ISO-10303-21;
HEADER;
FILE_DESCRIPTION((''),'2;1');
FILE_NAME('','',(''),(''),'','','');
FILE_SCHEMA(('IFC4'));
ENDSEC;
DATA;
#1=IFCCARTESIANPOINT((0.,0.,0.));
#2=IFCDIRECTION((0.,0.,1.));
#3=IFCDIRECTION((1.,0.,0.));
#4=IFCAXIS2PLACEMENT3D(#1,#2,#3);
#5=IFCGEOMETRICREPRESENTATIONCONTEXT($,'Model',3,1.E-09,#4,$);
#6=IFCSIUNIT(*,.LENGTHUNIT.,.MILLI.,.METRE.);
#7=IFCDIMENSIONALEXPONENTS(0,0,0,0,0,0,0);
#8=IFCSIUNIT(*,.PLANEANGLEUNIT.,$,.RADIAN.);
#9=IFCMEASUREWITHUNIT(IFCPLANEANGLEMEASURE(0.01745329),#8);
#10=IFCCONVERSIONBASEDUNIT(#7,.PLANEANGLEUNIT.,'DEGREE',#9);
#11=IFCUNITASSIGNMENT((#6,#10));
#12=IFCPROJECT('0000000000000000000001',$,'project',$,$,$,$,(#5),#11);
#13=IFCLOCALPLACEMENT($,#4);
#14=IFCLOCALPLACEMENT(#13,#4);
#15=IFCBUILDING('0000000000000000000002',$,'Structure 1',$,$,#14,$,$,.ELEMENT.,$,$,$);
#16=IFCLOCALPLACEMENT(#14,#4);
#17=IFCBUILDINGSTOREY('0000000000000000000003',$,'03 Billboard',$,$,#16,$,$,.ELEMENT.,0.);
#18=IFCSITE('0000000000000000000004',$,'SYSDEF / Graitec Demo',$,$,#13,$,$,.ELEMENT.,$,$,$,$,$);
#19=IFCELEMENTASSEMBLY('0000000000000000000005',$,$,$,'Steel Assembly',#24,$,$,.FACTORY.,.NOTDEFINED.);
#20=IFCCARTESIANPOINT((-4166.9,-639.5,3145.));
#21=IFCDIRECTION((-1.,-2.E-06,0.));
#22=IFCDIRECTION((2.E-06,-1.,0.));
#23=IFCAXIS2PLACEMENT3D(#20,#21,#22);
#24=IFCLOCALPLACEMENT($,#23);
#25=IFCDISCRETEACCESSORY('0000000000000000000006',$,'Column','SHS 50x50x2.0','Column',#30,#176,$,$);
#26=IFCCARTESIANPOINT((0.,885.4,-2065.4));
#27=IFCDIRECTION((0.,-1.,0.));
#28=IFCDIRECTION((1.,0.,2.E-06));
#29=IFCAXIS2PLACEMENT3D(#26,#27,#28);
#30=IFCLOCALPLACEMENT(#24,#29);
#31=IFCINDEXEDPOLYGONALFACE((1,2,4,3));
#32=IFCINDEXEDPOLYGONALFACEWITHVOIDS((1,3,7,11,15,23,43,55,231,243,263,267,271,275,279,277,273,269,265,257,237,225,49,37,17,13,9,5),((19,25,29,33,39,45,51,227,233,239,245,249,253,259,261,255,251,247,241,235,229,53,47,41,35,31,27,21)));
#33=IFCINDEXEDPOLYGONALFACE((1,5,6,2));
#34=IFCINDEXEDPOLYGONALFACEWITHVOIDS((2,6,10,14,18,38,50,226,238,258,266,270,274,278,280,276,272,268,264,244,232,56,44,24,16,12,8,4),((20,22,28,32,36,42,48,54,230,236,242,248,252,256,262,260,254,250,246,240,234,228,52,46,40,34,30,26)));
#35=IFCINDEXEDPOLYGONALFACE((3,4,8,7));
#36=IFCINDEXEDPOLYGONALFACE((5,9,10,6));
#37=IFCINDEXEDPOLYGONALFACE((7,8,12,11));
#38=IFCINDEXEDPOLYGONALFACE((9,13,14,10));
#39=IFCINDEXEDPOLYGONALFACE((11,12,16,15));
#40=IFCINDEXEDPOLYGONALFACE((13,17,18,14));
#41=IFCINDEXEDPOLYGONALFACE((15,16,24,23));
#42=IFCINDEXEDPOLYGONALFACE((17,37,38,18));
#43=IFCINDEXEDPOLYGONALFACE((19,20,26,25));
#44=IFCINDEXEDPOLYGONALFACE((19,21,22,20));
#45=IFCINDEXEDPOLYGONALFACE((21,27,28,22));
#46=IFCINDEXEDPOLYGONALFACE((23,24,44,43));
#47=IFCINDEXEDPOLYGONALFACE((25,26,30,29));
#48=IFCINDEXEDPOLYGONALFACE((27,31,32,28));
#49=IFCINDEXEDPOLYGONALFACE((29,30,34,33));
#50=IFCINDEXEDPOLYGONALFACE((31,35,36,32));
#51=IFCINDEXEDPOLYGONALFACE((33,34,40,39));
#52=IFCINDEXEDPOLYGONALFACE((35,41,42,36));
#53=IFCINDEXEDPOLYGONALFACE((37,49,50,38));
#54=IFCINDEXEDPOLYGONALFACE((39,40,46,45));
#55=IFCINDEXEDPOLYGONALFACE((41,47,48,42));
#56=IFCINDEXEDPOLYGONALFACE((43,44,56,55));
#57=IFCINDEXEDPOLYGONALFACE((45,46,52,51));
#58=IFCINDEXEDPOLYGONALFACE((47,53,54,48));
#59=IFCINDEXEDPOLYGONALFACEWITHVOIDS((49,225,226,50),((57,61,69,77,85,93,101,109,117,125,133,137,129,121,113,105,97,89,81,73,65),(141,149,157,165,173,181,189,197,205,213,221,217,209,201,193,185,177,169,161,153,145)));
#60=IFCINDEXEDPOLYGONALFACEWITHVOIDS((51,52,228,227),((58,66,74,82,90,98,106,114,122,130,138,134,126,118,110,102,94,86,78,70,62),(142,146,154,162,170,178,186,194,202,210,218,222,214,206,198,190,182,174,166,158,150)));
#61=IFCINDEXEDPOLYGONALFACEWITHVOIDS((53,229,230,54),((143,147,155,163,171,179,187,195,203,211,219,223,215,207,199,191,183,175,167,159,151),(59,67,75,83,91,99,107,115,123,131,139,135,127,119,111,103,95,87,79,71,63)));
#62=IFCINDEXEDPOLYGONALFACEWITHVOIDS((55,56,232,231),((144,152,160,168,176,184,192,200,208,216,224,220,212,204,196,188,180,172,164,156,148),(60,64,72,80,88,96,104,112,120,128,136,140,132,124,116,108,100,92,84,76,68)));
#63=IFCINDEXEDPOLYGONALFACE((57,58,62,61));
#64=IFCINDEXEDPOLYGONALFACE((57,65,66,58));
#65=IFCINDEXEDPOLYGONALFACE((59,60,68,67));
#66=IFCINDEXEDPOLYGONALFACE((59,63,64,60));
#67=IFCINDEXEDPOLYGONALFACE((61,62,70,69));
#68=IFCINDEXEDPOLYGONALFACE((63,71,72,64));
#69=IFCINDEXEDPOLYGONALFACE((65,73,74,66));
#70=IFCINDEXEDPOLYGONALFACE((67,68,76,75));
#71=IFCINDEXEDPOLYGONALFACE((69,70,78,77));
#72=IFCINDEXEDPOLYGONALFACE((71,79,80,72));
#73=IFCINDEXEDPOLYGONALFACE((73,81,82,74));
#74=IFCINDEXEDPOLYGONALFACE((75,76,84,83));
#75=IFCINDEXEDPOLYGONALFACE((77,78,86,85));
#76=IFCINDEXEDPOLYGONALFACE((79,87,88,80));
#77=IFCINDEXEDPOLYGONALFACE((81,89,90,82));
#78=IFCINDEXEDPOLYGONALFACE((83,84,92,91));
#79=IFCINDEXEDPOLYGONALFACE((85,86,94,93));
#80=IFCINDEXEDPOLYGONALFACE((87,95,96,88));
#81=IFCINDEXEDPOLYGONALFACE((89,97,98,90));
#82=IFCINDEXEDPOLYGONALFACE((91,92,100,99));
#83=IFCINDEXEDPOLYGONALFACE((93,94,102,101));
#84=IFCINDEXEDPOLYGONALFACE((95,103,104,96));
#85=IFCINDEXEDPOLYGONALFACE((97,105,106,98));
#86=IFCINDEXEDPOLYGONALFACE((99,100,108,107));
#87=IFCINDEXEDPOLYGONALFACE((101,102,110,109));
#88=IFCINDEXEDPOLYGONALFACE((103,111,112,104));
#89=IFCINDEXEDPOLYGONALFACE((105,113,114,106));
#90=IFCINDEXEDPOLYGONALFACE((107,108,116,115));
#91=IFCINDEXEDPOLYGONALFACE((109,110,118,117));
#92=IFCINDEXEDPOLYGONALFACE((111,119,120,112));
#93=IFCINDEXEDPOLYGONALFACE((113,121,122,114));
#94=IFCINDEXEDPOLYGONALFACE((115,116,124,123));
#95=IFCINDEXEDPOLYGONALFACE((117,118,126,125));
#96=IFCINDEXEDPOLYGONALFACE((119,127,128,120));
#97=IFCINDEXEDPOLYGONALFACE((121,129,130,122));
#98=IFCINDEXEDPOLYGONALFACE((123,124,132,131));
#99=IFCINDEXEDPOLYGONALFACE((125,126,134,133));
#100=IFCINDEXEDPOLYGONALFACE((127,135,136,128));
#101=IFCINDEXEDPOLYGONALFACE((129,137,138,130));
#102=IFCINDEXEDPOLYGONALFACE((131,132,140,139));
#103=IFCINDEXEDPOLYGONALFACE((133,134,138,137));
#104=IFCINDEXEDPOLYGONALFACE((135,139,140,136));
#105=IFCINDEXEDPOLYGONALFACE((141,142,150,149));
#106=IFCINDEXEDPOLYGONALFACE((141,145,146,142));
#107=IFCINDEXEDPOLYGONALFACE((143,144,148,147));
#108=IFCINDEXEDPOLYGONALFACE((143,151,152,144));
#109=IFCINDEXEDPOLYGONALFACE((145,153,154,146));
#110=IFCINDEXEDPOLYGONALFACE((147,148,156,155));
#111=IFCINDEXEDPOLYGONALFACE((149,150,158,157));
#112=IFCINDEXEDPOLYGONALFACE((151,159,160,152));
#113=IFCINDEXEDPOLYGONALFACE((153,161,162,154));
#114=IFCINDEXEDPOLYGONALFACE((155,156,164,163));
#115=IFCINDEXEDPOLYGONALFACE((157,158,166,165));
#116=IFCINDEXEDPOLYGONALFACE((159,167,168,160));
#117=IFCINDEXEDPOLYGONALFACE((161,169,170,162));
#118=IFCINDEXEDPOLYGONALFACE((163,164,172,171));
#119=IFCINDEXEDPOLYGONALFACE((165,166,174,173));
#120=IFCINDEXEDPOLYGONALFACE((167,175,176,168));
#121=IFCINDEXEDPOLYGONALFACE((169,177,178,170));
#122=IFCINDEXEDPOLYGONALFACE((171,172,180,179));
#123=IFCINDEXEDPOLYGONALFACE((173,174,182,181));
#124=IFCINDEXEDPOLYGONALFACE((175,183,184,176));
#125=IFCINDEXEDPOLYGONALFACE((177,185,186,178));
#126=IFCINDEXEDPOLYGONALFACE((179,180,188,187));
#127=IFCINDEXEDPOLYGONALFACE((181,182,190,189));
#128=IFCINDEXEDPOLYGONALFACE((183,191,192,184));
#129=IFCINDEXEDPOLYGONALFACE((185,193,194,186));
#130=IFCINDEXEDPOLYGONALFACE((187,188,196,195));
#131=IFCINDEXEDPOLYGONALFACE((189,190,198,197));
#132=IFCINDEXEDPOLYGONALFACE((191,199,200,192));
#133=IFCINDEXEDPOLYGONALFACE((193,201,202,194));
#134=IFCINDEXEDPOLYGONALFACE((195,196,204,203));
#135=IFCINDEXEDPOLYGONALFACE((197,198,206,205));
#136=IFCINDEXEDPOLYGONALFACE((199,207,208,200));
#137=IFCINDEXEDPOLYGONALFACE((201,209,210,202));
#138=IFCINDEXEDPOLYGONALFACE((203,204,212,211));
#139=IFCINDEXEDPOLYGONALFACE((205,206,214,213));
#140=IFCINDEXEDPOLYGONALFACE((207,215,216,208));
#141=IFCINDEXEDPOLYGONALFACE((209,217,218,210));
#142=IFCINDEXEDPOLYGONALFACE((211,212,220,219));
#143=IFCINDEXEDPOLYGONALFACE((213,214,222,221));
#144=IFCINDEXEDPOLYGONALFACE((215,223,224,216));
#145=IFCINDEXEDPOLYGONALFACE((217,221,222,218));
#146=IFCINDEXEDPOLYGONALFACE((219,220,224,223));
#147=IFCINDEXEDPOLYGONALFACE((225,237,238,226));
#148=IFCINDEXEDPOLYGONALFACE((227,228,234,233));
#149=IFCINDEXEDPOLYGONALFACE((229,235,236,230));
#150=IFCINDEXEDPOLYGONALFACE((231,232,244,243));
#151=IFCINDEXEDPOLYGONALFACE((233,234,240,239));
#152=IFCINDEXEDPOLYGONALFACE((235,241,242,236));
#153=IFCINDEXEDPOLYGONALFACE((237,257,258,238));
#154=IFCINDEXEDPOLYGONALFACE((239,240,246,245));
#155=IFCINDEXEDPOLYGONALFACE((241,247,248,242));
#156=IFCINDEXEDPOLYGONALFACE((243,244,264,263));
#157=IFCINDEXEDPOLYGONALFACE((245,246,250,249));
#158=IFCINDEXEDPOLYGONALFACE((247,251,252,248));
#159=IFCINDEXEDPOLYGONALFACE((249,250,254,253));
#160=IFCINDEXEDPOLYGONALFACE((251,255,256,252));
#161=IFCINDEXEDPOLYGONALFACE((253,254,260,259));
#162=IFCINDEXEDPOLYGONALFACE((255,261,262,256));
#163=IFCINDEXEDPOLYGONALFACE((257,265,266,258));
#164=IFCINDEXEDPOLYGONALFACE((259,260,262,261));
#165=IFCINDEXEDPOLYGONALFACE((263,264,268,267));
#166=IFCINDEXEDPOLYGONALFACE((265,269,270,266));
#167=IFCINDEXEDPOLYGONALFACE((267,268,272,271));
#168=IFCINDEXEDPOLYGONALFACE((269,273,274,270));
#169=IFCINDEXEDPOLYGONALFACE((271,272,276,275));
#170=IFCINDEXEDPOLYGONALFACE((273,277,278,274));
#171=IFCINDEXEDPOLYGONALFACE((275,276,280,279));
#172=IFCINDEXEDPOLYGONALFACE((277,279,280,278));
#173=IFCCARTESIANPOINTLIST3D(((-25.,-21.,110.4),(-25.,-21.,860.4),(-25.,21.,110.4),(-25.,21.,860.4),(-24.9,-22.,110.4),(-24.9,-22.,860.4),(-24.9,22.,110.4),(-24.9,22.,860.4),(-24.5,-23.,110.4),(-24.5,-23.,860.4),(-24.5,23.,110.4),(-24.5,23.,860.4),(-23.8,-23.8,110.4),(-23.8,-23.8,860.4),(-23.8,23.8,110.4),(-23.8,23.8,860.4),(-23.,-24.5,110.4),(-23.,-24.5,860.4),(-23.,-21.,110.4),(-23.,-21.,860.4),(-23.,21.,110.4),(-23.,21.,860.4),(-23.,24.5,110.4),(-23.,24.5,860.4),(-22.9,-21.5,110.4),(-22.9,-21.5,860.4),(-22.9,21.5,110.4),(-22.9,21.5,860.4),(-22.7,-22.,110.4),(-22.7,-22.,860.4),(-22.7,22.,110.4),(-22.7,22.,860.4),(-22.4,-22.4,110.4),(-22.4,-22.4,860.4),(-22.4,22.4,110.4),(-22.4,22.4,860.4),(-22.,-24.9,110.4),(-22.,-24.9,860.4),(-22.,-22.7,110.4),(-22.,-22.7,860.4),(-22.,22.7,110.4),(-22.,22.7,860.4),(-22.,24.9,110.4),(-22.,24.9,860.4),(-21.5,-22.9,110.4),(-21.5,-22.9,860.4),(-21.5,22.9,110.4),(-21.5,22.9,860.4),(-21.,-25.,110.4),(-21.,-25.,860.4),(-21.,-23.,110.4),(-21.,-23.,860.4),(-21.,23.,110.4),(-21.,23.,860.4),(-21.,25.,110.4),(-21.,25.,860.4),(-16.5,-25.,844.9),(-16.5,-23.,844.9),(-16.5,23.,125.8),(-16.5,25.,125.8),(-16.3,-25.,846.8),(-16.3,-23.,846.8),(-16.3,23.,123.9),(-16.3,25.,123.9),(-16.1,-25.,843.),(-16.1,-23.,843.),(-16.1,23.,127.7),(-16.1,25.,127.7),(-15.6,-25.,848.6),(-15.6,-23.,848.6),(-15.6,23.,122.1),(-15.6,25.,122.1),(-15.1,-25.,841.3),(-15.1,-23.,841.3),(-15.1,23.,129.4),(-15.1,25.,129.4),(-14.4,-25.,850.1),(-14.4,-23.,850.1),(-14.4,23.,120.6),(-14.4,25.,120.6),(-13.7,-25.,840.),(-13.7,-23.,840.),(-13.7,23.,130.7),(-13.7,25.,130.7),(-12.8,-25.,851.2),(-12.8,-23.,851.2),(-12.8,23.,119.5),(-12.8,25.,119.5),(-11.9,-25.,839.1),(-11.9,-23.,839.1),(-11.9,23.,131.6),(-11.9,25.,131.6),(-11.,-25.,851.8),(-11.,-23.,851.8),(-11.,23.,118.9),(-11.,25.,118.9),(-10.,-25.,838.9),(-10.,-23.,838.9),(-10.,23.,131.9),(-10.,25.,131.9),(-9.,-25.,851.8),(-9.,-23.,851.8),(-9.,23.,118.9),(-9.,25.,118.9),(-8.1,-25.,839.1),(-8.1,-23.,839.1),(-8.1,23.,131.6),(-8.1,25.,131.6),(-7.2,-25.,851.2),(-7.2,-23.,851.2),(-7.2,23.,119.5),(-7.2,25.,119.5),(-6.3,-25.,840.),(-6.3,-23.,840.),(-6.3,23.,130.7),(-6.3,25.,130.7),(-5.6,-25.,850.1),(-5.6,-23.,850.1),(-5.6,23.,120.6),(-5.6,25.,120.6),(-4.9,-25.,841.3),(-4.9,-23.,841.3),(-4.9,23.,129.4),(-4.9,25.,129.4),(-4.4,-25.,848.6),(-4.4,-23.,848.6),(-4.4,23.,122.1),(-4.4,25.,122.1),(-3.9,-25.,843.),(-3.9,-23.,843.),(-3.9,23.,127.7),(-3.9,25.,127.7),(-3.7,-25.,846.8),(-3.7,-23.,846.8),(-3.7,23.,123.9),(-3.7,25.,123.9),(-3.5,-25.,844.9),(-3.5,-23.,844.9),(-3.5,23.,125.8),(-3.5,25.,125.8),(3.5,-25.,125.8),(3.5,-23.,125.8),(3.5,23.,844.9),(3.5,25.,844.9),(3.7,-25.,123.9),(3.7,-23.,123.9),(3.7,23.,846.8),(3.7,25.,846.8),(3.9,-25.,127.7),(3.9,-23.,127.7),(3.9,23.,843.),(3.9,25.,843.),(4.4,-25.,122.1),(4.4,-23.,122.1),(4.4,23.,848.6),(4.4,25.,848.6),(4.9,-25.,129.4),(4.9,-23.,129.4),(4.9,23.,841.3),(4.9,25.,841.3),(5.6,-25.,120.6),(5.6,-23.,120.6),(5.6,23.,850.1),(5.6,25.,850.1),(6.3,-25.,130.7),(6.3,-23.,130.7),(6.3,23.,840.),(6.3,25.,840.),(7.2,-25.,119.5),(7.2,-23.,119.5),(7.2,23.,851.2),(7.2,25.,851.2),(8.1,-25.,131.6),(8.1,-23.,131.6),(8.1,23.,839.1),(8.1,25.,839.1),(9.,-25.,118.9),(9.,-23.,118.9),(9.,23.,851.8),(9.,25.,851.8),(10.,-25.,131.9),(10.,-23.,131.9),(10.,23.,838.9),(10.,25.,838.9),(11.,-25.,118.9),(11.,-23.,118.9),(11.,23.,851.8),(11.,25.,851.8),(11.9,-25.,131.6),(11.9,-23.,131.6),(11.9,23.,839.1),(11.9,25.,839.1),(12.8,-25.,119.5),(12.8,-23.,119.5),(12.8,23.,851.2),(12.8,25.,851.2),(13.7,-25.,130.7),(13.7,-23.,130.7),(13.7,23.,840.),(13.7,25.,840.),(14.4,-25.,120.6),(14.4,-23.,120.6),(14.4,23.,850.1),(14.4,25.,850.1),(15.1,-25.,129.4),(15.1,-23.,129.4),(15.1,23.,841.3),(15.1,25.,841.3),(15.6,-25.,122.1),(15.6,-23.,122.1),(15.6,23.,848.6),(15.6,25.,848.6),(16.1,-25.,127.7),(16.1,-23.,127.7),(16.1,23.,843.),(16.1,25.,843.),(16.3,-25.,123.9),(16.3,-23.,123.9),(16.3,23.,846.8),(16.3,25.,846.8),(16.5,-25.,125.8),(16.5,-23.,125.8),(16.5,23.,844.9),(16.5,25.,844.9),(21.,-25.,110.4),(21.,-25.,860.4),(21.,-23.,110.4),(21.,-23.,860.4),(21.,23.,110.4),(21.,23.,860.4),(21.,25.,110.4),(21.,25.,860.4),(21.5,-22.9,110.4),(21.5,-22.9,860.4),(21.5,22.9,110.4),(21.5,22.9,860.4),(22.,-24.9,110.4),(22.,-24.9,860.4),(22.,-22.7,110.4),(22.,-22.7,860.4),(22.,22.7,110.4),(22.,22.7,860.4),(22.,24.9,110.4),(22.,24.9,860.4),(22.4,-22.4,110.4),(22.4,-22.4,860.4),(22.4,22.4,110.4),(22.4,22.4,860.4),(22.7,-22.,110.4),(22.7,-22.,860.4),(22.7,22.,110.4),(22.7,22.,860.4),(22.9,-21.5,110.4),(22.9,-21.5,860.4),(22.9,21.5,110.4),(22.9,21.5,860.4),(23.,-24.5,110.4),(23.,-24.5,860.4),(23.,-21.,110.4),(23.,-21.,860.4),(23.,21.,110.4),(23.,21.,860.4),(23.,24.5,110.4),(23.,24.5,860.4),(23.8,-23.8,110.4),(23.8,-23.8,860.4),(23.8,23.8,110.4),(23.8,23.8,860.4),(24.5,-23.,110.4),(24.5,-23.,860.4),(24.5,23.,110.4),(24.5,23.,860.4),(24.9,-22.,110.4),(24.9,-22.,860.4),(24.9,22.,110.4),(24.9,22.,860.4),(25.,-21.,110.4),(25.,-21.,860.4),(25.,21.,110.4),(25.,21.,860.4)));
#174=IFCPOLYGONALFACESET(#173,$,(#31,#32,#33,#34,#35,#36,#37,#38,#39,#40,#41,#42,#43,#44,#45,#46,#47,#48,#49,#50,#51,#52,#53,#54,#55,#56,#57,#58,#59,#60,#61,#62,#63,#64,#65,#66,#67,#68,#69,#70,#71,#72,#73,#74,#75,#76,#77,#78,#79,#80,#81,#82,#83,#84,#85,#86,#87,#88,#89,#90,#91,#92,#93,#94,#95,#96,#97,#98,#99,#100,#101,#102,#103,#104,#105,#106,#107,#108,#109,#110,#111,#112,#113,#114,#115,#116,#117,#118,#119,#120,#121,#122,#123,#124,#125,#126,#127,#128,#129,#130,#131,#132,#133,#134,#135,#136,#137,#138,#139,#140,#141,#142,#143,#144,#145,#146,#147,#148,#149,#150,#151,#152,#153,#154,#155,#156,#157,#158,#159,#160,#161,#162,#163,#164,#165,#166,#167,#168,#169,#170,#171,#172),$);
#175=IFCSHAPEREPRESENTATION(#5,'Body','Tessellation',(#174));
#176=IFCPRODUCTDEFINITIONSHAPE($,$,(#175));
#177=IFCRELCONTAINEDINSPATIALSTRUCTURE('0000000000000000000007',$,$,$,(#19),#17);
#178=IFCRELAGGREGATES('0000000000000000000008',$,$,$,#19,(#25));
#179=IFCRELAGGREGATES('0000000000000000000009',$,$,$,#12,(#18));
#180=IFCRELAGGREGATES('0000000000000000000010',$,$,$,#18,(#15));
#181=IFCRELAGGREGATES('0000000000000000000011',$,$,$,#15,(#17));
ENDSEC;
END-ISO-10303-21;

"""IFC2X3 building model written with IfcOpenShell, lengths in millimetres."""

from ifc_helpers import new_model, entity, si_unit, converted_unit, frame, origin, origin_with_axes, origin_2d, origin_2d_with_axis, place, context, project, spatial, hollow_rectangle, circle, extrude, clip, halfspace, element, aggregate, save


model = new_model("IFC2X3")

# Units and contexts
model_context = context("Model", 3, precision=1e-09, world=origin_with_axes())
ifc_project = project(units=[si_unit("LENGTHUNIT", "METRE", prefix="MILLI"), converted_unit("PLANEANGLEUNIT", "DEGREE", entity("IfcPlaneAngleMeasure", 0.01745329), si_unit("PLANEANGLEUNIT", "RADIAN"), dimensions=[0, 0, 0, 0, 0, 0, 0])], contexts=[model_context])

# Site, building, storey
site_placement = place(None, origin_with_axes())
site = spatial("IfcSite", under=ifc_project, at=site_placement, Name="SYSDEF / Graitec Demo", CompositionType="ELEMENT")
building_placement = place(site_placement, origin_with_axes())
building = spatial("IfcBuilding", under=site, at=building_placement, Name="Structure 1", CompositionType="ELEMENT")
storey_placement = place(building_placement, origin_with_axes())
storey = spatial("IfcBuildingStorey", under=building, at=storey_placement, Name="03 Billboard", CompositionType="ELEMENT", Elevation=0.0)

# Element assembly, discrete accessory, openings
assembly_1_placement = place(None, frame((-4166.9, -639.5, 3145.0), z_axis=(-1.0, -0.000002, 0.0), x_axis=(0.000002, -1.0, 0.0)))
assembly_1 = element("IfcElementAssembly", 1, at=assembly_1_placement, inside=storey, ObjectType="Steel Assembly", AssemblyPlace="FACTORY", PredefinedType="NOTDEFINED")
discrete_accessory_1_placement = place(assembly_1_placement, frame((0.0, 885.4, -2065.4), z_axis=(0.0, -1.0, 0.0), x_axis=(1.0, 0.0, 0.000002)))
discrete_accessory_1 = element("IfcDiscreteAccessory", 2, at=discrete_accessory_1_placement, Name="Column", Description="SHS 50x50x2.0", ObjectType="Column", context=model_context, shape_type="Clipping", body=[
    clip(clip(extrude(hollow_rectangle(XDim=50.0, YDim=50.0, WallThickness=2.0, InnerFilletRadius=2.0, OuterFilletRadius=4.0, at=origin_2d()), origin(), (0.0, 0.0, 1.0), 920.7), halfspace(frame((-639.5, -2101.5, 110.4), z_axis=(0.0, 0.0, 1.0), x_axis=(0.0, 1.0, 0.0)), True)), halfspace(frame((-639.5, -2101.5, 860.4), z_axis=(0.0, 0.0, -1.0), x_axis=(0.0, -1.0, 0.0)), True)),
])
opening_1_placement = place(discrete_accessory_1_placement, frame((-10.0, 22.5, 125.4), z_axis=(0.0, 1.0, 0.0), x_axis=(0.0, 0.0, 1.0)))
element("IfcOpeningElement", 3, at=opening_1_placement, cuts=discrete_accessory_1, ObjectType="Opening", context=model_context, shape_type="SweptSolid", body=[
    extrude(circle(Radius=6.5, at=origin_2d_with_axis()), origin(), (0.0, 0.0, 1.0), 3.0),
])
opening_2_placement = place(discrete_accessory_1_placement, frame((10.0, 22.5, 845.4), z_axis=(0.0, 1.0, 0.0), x_axis=(0.0, 0.0, -1.0)))
element("IfcOpeningElement", 4, at=opening_2_placement, cuts=discrete_accessory_1, ObjectType="Opening", context=model_context, shape_type="SweptSolid", body=[
    extrude(circle(Radius=6.5, at=origin_2d_with_axis()), origin(), (0.0, 0.0, 1.0), 3.0),
])
opening_3_placement = place(discrete_accessory_1_placement, frame((10.0, -22.5, 125.4), z_axis=(0.0, -1.0, 0.0), x_axis=(0.0, 0.0, 1.0)))
element("IfcOpeningElement", 5, at=opening_3_placement, cuts=discrete_accessory_1, ObjectType="Opening", context=model_context, shape_type="SweptSolid", body=[
    extrude(circle(Radius=6.5, at=origin_2d_with_axis()), origin(), (0.0, 0.0, 1.0), 3.0),
])
opening_4_placement = place(discrete_accessory_1_placement, frame((-10.0, -22.5, 845.4), z_axis=(0.0, -1.0, 0.0), x_axis=(0.0, 0.0, -1.0)))
element("IfcOpeningElement", 6, at=opening_4_placement, cuts=discrete_accessory_1, ObjectType="Opening", context=model_context, shape_type="SweptSolid", body=[
    extrude(circle(Radius=6.5, at=origin_2d_with_axis()), origin(), (0.0, 0.0, 1.0), 3.0),
])
aggregate(assembly_1, [discrete_accessory_1])

save(model, "model.ifc")
